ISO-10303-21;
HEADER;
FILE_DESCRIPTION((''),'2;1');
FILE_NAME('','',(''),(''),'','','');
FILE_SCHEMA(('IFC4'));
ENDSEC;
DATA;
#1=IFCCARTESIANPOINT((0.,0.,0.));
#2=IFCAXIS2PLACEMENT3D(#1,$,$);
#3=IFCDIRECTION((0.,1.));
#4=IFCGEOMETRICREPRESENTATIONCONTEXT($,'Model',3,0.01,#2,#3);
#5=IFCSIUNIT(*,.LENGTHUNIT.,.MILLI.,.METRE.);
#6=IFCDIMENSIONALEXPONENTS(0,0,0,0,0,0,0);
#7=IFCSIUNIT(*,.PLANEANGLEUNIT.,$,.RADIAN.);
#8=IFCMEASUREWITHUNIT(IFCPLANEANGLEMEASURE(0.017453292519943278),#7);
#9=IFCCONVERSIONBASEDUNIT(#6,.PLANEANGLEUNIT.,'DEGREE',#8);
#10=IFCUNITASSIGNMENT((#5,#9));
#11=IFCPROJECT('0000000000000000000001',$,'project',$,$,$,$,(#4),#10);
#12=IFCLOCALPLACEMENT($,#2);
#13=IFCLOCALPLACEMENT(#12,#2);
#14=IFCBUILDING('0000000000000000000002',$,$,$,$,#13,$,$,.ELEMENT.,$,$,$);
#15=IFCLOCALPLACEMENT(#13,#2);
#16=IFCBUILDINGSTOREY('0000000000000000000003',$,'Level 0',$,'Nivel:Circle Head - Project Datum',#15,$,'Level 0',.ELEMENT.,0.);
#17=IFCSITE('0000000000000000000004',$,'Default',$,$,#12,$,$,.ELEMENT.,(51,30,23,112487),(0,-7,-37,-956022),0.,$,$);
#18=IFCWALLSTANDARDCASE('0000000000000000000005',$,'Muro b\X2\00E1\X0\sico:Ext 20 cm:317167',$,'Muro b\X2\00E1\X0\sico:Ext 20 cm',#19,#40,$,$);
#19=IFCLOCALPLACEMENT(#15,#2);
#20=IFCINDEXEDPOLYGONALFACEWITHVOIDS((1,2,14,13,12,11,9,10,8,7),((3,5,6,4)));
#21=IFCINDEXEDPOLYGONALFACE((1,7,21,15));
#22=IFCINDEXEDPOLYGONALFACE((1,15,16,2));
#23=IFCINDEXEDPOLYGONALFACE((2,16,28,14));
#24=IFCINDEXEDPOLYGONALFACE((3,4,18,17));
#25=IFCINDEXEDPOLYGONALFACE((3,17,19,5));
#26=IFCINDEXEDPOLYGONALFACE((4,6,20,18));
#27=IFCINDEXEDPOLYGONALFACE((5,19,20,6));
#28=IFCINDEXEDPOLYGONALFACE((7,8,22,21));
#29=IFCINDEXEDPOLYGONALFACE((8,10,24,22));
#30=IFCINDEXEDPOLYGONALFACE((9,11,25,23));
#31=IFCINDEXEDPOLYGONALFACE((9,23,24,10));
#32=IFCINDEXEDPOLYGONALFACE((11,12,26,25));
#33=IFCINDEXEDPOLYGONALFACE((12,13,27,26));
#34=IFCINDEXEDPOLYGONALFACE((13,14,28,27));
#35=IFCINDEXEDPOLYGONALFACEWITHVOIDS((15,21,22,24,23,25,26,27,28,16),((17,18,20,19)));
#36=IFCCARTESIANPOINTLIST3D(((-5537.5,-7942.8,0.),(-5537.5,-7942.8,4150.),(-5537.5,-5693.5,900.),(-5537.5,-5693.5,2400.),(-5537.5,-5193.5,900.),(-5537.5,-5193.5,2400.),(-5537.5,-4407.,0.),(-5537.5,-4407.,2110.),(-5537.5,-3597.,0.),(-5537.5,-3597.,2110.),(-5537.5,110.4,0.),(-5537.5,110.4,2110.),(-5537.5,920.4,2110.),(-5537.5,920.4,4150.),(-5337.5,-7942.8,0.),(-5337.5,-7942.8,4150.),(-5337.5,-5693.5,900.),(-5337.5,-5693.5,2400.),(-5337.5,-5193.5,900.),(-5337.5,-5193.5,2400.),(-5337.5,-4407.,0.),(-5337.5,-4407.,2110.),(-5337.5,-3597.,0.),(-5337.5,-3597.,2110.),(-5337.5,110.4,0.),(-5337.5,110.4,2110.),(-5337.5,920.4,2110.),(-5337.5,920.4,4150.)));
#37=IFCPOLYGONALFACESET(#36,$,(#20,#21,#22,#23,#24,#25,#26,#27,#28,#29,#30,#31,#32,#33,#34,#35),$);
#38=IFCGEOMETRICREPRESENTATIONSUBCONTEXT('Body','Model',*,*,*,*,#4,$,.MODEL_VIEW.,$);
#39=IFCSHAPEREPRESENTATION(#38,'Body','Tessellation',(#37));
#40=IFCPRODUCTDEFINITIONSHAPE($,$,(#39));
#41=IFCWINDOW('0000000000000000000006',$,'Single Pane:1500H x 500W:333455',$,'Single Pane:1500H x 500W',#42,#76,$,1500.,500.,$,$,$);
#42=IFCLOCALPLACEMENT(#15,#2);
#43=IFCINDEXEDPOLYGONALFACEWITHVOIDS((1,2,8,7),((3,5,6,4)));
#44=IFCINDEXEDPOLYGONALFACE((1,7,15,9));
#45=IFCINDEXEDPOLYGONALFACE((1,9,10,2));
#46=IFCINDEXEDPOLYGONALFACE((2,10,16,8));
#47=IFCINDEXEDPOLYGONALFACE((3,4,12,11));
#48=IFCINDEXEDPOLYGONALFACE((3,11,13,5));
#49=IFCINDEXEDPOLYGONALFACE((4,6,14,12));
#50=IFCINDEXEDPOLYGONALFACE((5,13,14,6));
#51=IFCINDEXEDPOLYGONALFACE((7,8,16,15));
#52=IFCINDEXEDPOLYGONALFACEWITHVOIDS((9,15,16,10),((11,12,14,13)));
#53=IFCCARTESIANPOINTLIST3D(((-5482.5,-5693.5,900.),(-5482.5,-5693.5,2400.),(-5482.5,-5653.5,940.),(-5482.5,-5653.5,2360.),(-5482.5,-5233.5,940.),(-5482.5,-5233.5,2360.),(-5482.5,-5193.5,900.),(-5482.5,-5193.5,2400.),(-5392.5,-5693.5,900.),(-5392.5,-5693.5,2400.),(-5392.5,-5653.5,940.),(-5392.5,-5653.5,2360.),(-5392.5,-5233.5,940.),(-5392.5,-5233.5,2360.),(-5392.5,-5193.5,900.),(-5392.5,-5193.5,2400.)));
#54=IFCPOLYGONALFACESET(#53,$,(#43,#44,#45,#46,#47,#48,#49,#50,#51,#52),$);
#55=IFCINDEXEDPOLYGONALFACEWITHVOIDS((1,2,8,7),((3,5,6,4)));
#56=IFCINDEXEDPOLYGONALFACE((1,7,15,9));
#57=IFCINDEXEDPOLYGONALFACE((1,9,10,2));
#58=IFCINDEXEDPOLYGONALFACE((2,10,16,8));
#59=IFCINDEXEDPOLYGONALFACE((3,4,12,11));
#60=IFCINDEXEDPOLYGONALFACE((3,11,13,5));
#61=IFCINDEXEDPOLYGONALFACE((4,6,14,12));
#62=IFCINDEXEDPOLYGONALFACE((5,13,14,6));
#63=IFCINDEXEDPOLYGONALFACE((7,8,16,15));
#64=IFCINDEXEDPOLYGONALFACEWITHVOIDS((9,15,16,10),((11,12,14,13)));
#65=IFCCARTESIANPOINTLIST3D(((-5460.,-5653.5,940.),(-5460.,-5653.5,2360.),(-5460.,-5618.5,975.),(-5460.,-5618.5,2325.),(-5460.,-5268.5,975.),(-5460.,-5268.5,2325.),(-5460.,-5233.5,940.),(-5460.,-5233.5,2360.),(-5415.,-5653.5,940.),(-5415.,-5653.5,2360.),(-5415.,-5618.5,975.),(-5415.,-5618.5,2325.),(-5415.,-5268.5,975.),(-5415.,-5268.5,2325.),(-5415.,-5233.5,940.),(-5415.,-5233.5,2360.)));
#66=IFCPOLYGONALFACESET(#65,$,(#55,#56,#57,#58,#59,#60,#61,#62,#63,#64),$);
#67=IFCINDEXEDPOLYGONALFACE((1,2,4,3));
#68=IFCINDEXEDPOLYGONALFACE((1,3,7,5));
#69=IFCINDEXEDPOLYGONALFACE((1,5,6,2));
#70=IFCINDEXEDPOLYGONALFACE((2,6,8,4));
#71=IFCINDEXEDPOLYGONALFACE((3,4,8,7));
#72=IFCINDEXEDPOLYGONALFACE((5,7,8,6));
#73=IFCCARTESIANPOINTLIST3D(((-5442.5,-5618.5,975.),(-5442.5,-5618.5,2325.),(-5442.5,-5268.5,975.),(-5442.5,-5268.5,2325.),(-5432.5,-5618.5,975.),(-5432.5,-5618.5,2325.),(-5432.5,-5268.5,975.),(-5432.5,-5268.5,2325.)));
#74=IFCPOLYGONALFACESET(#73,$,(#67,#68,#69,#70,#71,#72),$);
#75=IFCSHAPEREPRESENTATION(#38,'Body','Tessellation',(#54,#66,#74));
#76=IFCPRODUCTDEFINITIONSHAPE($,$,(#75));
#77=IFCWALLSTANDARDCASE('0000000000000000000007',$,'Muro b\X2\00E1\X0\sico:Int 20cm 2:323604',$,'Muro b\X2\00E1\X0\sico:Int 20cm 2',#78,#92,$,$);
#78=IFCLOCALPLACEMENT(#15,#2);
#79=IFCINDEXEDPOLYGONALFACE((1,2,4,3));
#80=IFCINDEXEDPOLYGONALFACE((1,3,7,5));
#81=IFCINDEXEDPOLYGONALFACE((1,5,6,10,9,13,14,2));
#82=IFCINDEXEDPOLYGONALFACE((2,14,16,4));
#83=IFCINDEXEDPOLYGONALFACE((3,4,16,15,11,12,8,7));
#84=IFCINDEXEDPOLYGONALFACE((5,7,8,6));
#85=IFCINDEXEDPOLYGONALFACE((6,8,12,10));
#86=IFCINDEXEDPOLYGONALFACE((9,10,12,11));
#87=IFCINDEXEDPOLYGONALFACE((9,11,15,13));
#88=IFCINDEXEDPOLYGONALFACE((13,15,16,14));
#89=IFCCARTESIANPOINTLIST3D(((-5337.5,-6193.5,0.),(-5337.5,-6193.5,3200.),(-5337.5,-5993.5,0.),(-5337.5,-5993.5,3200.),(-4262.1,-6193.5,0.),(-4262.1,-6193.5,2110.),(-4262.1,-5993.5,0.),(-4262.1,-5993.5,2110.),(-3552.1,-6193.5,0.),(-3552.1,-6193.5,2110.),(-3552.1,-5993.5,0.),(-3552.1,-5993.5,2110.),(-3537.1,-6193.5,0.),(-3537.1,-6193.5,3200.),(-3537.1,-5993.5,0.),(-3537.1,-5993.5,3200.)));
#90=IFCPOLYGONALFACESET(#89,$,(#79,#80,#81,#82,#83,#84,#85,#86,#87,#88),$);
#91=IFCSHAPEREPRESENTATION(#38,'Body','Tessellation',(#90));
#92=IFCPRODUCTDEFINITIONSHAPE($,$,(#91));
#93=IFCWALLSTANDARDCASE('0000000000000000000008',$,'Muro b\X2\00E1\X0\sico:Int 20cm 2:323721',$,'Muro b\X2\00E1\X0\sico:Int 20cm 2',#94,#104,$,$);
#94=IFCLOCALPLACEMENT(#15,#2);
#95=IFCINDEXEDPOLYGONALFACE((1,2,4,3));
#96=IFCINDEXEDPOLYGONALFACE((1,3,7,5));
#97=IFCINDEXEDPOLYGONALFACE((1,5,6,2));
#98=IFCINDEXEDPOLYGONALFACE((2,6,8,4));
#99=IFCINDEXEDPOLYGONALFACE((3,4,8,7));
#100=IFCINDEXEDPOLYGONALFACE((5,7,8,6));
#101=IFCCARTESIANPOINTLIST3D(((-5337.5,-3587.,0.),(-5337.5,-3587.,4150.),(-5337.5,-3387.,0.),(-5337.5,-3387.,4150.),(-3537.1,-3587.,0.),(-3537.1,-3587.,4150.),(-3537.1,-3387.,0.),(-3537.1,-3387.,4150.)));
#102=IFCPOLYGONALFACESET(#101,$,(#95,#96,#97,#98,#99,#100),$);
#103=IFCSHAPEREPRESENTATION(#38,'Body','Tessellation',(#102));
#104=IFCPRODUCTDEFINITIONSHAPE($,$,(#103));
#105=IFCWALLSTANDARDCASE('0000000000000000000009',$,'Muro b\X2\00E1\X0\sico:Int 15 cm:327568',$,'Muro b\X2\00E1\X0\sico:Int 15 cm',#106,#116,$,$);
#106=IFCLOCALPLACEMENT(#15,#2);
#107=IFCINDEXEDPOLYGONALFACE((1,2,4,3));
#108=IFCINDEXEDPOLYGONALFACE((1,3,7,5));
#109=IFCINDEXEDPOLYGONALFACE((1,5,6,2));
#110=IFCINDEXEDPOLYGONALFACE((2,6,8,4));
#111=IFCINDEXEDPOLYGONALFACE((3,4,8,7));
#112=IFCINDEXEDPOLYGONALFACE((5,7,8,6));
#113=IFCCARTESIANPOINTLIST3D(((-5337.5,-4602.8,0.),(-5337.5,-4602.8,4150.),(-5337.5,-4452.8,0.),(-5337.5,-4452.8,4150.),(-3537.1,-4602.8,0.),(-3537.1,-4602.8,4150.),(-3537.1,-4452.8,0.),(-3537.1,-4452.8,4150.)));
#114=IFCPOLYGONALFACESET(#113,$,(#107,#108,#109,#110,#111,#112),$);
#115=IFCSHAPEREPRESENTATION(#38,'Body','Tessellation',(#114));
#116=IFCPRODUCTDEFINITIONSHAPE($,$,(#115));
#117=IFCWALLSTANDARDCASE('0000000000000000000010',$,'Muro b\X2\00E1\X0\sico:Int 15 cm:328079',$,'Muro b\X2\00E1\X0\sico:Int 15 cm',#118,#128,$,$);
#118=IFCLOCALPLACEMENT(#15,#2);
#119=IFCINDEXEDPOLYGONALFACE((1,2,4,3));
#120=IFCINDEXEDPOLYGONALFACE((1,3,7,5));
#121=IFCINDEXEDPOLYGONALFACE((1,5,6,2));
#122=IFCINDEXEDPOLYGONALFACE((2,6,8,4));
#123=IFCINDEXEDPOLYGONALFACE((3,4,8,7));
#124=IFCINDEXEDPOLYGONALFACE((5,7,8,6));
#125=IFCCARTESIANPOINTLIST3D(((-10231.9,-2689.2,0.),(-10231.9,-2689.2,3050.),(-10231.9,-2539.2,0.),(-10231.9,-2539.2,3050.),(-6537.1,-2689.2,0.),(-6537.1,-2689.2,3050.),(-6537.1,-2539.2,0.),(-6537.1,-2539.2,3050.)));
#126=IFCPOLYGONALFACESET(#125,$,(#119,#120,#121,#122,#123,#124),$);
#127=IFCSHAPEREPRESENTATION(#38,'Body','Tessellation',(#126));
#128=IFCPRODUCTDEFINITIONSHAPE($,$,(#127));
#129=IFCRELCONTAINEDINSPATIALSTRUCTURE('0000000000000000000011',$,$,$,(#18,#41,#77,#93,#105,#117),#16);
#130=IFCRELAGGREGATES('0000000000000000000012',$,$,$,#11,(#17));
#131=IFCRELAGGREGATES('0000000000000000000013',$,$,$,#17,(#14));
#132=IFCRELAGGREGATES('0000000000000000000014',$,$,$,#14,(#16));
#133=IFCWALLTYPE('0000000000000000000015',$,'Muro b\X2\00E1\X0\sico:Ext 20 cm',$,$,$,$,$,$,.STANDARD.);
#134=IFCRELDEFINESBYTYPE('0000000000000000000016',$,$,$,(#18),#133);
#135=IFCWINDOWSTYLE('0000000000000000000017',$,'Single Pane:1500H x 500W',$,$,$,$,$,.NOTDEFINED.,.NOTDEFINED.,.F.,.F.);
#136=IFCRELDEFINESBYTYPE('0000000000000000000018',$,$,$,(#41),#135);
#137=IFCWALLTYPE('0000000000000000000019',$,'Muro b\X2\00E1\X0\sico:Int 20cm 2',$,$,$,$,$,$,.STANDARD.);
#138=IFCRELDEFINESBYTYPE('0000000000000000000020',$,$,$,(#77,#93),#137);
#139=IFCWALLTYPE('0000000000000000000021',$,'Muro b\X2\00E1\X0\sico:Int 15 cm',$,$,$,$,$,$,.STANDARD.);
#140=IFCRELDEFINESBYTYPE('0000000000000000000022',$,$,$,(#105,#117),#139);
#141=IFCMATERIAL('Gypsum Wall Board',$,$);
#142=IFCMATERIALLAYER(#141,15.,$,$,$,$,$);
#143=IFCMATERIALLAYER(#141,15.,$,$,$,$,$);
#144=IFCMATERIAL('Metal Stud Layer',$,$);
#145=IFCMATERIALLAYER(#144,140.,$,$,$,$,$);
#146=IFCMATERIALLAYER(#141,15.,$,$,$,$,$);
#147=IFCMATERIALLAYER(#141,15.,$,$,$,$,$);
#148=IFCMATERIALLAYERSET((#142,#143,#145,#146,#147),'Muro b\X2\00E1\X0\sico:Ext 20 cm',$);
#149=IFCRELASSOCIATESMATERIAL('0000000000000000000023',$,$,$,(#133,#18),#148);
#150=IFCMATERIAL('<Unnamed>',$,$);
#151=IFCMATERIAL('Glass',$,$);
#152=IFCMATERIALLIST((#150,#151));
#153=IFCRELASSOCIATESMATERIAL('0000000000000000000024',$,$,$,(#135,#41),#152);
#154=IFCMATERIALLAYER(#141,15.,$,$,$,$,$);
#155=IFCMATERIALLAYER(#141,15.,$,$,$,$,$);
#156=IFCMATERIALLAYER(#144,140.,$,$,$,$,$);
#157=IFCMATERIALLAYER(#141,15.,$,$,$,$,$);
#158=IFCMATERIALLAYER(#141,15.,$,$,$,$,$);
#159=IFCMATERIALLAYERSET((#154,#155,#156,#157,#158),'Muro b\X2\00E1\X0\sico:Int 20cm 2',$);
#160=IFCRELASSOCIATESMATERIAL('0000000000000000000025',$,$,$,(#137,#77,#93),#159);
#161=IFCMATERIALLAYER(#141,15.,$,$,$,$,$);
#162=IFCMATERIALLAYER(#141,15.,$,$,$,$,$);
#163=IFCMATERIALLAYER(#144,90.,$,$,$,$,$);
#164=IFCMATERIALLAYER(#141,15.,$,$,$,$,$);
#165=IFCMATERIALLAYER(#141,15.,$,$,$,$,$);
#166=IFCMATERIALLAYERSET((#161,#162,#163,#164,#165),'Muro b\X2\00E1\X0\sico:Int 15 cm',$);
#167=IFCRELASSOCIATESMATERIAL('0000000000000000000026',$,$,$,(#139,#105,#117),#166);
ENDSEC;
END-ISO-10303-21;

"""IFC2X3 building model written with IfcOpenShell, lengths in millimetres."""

from ifc_helpers import new_model, entity, si_unit, converted_unit, direction, frame, frame_2d, origin, origin_2d_with_axis, place, context, subcontext, project, spatial, polyline, rectangle, outline, extrude, clip, bounded_halfspace, source, transform, mapped, material, material_list, layer, layer_set, layer_usage, type_object, type_shapes, element, fill, save


model = new_model("IFC2X3")

# Units and contexts
model_context = context("Model", 3, precision=0.01, world=origin(), true_north=direction((0.0, 1.0)))
body_context = subcontext(model_context, "Body", "Model", "MODEL_VIEW")
ifc_project = project(units=[si_unit("LENGTHUNIT", "METRE", prefix="MILLI"), converted_unit("PLANEANGLEUNIT", "DEGREE", entity("IfcPlaneAngleMeasure", 0.017453292519943278), si_unit("PLANEANGLEUNIT", "RADIAN"), dimensions=[0, 0, 0, 0, 0, 0, 0])], contexts=[model_context])

# Site, building, storey
site_placement = place(None, origin())
site = spatial("IfcSite", under=ifc_project, at=site_placement, Name="Default", CompositionType="ELEMENT", RefLatitude=(51, 30, 23, 112487), RefLongitude=(0, -7, -37, -956022), RefElevation=0.0)
building_placement = place(site_placement, origin())
building = spatial("IfcBuilding", under=site, at=building_placement, CompositionType="ELEMENT")
storey_placement = place(building_placement, origin())
storey = spatial("IfcBuildingStorey", under=building, at=storey_placement, Name="Level 0", ObjectType="Nivel:Circle Head - Project Datum", LongName="Level 0", CompositionType="ELEMENT", Elevation=0.0)

# Shared definitions
ifc_material_1 = material(Name="<Unnamed>")

# Shared definitions
ifc_material_2 = material(Name="Gypsum Wall Board")
ifc_layer_1 = layer(ifc_material_2, 15.0)
ifc_layer_2 = layer(ifc_material_2, 15.0)
ifc_material_3 = material(Name="Metal Stud Layer")
ifc_layer_3 = layer(ifc_material_3, 140.0)
ifc_layer_4 = layer(ifc_material_2, 15.0)
ifc_layer_5 = layer(ifc_material_2, 15.0)
ifc_layer_set_1 = layer_set([ifc_layer_1, ifc_layer_2, ifc_layer_3, ifc_layer_4, ifc_layer_5], Name="Muro básico:Ext 20 cm")
wall_type_1 = type_object("IfcWallType", Name="Muro básico:Ext 20 cm", PredefinedType="STANDARD", material=ifc_layer_set_1)

# Shared definitions
ifc_material_4 = material(Name="Glass")
ifc_material_list = material_list([ifc_material_1, ifc_material_4])

# Wall, openings, window
ifc_layer_usage_1 = layer_usage(ifc_layer_set_1, "AXIS2", "NEGATIVE", 100.0)
wall_1_placement = place(storey_placement, frame((-5437.5, -7942.8, 0.0), z_axis=(0.0, 0.0, 1.0), x_axis=(0.0, 1.0, 0.0)))
wall_1 = element("IfcWallStandardCase", 1, at=wall_1_placement, inside=storey, type_object=wall_type_1, material=ifc_layer_usage_1, Name="Muro básico:Ext 20 cm:317167", ObjectType="Muro básico:Ext 20 cm", context=body_context, shape_type="SweptSolid", body=[
    extrude(rectangle(XDim=8863.2, YDim=200.0, at=frame_2d((4431.6, 0.0), x_axis=(1.0, 0.0))), origin(), (0.0, 0.0, 1.0), 4150.0),
])
opening_1_placement = place(wall_1_placement, frame((4345.7, 100.0, 0.0)))
element("IfcOpeningElement", 2, at=opening_1_placement, cuts=wall_1, ObjectType="Opening", context=body_context, shape_type="SweptSolid", body=[
    extrude(rectangle(XDim=2110.0, YDim=810.0, at=frame_2d((1055.0, 405.0), x_axis=(1.0, 0.0))), frame((0.0, 0.0, 0.0), z_axis=(0.0, -1.0, 0.0), x_axis=(0.0, 0.0, 1.0)), (0.0, 0.0, 1.0), 200.0),
])
opening_2_placement = place(wall_1_placement, frame((8053.2, -100.0, 0.0)))
element("IfcOpeningElement", 3, at=opening_2_placement, cuts=wall_1, ObjectType="Opening", context=body_context, shape_type="SweptSolid", body=[
    extrude(rectangle(XDim=2110.0, YDim=810.0, at=frame_2d((1055.0, 405.0), x_axis=(1.0, 0.0))), frame((0.0, 0.0, 0.0), z_axis=(0.0, 1.0, 0.0), x_axis=(0.0, 0.0, 1.0)), (0.0, 0.0, 1.0), 200.0),
])
opening_3_placement = place(wall_1_placement, frame((2249.3, -100.0, 900.0)))
opening_3 = element("IfcOpeningElement", 4, at=opening_3_placement, cuts=wall_1, ObjectType="Opening", context=body_context, shape_type="SweptSolid", body=[
    extrude(rectangle(XDim=1500.0, YDim=500.0, at=frame_2d((750.0, 250.0), x_axis=(1.0, 0.0))), frame((0.0, 0.0, 0.0), z_axis=(0.0, 1.0, 0.0), x_axis=(0.0, 0.0, 1.0)), (0.0, 0.0, 1.0), 200.0),
])
window_style_1 = type_object("IfcWindowStyle", Name="Single Pane:1500H x 500W", ConstructionType="NOTDEFINED", OperationType="NOTDEFINED", ParameterTakesPrecedence=False, Sizeable=False, material=ifc_material_list)
shared_shape_1 = source(origin(), body_context, "Body", "SweptSolid", [
    extrude(outline(polyline([(-250.0, -750.0), (250.0, -750.0), (250.0, 750.0), (-250.0, 750.0), (-250.0, -750.0)]), holes=[polyline([(-210.0, -710.0), (-210.0, 710.0), (210.0, 710.0), (210.0, -710.0), (-210.0, -710.0)])]), frame((250.0, 55.0, 750.0), z_axis=(0.0, 1.0, 0.0), x_axis=(1.0, 0.0, 0.0)), (0.0, 0.0, 1.0), 90.0),
    extrude(outline(polyline([(-210.0, -710.0), (210.0, -710.0), (210.0, 710.0), (-210.0, 710.0), (-210.0, -710.0)]), holes=[polyline([(-175.0, -675.0), (-175.0, 675.0), (175.0, 675.0), (175.0, -675.0), (-175.0, -675.0)])]), frame((250.0, 77.5, 750.0), z_axis=(0.0, 1.0, 0.0), x_axis=(1.0, 0.0, 0.0)), (0.0, 0.0, 1.0), 45.0),
    extrude(rectangle(XDim=10.0, YDim=350.0, at=origin_2d_with_axis()), frame((250.0, 100.0, 75.0), z_axis=(0.0, 0.0, 1.0), x_axis=(0.0, 1.0, 0.0)), (0.0, 0.0, 1.0), 1350.0),
])
type_shapes(window_style_1, [shared_shape_1])
window_1_placement = place(opening_3_placement, origin())
window_1 = element("IfcWindow", 5, at=window_1_placement, inside=storey, type_object=window_style_1, material=ifc_material_list, Name="Single Pane:1500H x 500W:333455", ObjectType="Single Pane:1500H x 500W", OverallHeight=1500.0, OverallWidth=500.0, context=body_context, shape_type="MappedRepresentation", body=[
    mapped(shared_shape_1, transform((0.0, 0.0, 0.0), scale=1.0)),
])
fill(opening_3, window_1)

# Wall, opening
ifc_layer_6 = layer(ifc_material_2, 15.0)
ifc_layer_7 = layer(ifc_material_2, 15.0)
ifc_layer_8 = layer(ifc_material_3, 140.0)
ifc_layer_9 = layer(ifc_material_2, 15.0)
ifc_layer_10 = layer(ifc_material_2, 15.0)
ifc_layer_set_2 = layer_set([ifc_layer_6, ifc_layer_7, ifc_layer_8, ifc_layer_9, ifc_layer_10], Name="Muro básico:Int 20cm 2")
ifc_layer_usage_2 = layer_usage(ifc_layer_set_2, "AXIS2", "NEGATIVE", 100.0)
wall_type_2 = type_object("IfcWallType", Name="Muro básico:Int 20cm 2", PredefinedType="STANDARD", material=ifc_layer_set_2)
wall_2_placement = place(storey_placement, frame((-5337.5, -6093.5, 0.0)))
wall_2 = element("IfcWallStandardCase", 6, at=wall_2_placement, inside=storey, type_object=wall_type_2, material=ifc_layer_usage_2, Name="Muro básico:Int 20cm 2:323604", ObjectType="Muro básico:Int 20cm 2", context=body_context, shape_type="SweptSolid", body=[
    extrude(rectangle(XDim=1800.3, YDim=200.0, at=frame_2d((900.2, 0.0), x_axis=(-1.0, 0.0))), origin(), (0.0, 0.0, 1.0), 3200.0),
])
opening_4_placement = place(wall_2_placement, frame((1785.3, 100.0, 0.0)))
element("IfcOpeningElement", 7, at=opening_4_placement, cuts=wall_2, ObjectType="Opening", context=body_context, shape_type="SweptSolid", body=[
    extrude(rectangle(XDim=2110.0, YDim=710.0, at=frame_2d((1055.0, 355.0), x_axis=(1.0, 0.0))), frame((0.0, 0.0, 0.0), z_axis=(0.0, -1.0, 0.0), x_axis=(0.0, 0.0, 1.0)), (0.0, 0.0, 1.0), 200.0),
])

# Walls
ifc_layer_usage_3 = layer_usage(ifc_layer_set_2, "AXIS2", "NEGATIVE", 100.0)
wall_3_placement = place(storey_placement, frame((-3537.1, -3487.0, 0.0), z_axis=(0.0, 0.0, 1.0), x_axis=(-1.0, 0.0, 0.0)))
element("IfcWallStandardCase", 8, at=wall_3_placement, inside=storey, type_object=wall_type_2, material=ifc_layer_usage_3, Name="Muro básico:Int 20cm 2:323721", ObjectType="Muro básico:Int 20cm 2", context=body_context, shape_type="SweptSolid", body=[
    extrude(rectangle(XDim=1800.3, YDim=200.0, at=frame_2d((900.2, 0.0), x_axis=(-1.0, 0.0))), origin(), (0.0, 0.0, 1.0), 4150.0),
])
ifc_layer_11 = layer(ifc_material_2, 15.0)
ifc_layer_12 = layer(ifc_material_2, 15.0)
ifc_layer_13 = layer(ifc_material_3, 90.0)
ifc_layer_14 = layer(ifc_material_2, 15.0)
ifc_layer_15 = layer(ifc_material_2, 15.0)
ifc_layer_set_3 = layer_set([ifc_layer_11, ifc_layer_12, ifc_layer_13, ifc_layer_14, ifc_layer_15], Name="Muro básico:Int 15 cm")
ifc_layer_usage_4 = layer_usage(ifc_layer_set_3, "AXIS2", "NEGATIVE", 75.0)
wall_type_3 = type_object("IfcWallType", Name="Muro básico:Int 15 cm", PredefinedType="STANDARD", material=ifc_layer_set_3)
wall_4_placement = place(storey_placement, frame((-5337.5, -4527.8, 0.0)))
element("IfcWallStandardCase", 9, at=wall_4_placement, inside=storey, type_object=wall_type_3, material=ifc_layer_usage_4, Name="Muro básico:Int 15 cm:327568", ObjectType="Muro básico:Int 15 cm", context=body_context, shape_type="SweptSolid", body=[
    extrude(rectangle(XDim=1800.3, YDim=150.0, at=frame_2d((900.2, 0.0), x_axis=(-1.0, 0.0))), origin(), (0.0, 0.0, 1.0), 4150.0),
])
ifc_layer_usage_5 = layer_usage(ifc_layer_set_3, "AXIS2", "NEGATIVE", 75.0)
wall_5_placement = place(storey_placement, frame((-10231.9, -2614.2, 0.0)))
element("IfcWallStandardCase", 10, at=wall_5_placement, inside=storey, type_object=wall_type_3, material=ifc_layer_usage_5, Name="Muro básico:Int 15 cm:328079", ObjectType="Muro básico:Int 15 cm", context=body_context, shape_type="Clipping", body=[
    clip(extrude(rectangle(XDim=3694.8, YDim=150.0, at=frame_2d((1847.4, 0.0), x_axis=(-1.0, 0.0))), origin(), (0.0, 0.0, 1.0), 3050.0), bounded_halfspace(frame((0.0, -75.0, 3050.0), z_axis=(0.0, 0.0, -1.0), x_axis=(0.0, -1.0, 0.0)), True, frame((0.0, -75.0, 3050.0)), polyline([(0.0, 0.0), (3694.8, 0.0), (3694.8, 125.0), (0.0, 125.0), (0.0, 0.0)]))),
])

save(model, "model.ifc")
